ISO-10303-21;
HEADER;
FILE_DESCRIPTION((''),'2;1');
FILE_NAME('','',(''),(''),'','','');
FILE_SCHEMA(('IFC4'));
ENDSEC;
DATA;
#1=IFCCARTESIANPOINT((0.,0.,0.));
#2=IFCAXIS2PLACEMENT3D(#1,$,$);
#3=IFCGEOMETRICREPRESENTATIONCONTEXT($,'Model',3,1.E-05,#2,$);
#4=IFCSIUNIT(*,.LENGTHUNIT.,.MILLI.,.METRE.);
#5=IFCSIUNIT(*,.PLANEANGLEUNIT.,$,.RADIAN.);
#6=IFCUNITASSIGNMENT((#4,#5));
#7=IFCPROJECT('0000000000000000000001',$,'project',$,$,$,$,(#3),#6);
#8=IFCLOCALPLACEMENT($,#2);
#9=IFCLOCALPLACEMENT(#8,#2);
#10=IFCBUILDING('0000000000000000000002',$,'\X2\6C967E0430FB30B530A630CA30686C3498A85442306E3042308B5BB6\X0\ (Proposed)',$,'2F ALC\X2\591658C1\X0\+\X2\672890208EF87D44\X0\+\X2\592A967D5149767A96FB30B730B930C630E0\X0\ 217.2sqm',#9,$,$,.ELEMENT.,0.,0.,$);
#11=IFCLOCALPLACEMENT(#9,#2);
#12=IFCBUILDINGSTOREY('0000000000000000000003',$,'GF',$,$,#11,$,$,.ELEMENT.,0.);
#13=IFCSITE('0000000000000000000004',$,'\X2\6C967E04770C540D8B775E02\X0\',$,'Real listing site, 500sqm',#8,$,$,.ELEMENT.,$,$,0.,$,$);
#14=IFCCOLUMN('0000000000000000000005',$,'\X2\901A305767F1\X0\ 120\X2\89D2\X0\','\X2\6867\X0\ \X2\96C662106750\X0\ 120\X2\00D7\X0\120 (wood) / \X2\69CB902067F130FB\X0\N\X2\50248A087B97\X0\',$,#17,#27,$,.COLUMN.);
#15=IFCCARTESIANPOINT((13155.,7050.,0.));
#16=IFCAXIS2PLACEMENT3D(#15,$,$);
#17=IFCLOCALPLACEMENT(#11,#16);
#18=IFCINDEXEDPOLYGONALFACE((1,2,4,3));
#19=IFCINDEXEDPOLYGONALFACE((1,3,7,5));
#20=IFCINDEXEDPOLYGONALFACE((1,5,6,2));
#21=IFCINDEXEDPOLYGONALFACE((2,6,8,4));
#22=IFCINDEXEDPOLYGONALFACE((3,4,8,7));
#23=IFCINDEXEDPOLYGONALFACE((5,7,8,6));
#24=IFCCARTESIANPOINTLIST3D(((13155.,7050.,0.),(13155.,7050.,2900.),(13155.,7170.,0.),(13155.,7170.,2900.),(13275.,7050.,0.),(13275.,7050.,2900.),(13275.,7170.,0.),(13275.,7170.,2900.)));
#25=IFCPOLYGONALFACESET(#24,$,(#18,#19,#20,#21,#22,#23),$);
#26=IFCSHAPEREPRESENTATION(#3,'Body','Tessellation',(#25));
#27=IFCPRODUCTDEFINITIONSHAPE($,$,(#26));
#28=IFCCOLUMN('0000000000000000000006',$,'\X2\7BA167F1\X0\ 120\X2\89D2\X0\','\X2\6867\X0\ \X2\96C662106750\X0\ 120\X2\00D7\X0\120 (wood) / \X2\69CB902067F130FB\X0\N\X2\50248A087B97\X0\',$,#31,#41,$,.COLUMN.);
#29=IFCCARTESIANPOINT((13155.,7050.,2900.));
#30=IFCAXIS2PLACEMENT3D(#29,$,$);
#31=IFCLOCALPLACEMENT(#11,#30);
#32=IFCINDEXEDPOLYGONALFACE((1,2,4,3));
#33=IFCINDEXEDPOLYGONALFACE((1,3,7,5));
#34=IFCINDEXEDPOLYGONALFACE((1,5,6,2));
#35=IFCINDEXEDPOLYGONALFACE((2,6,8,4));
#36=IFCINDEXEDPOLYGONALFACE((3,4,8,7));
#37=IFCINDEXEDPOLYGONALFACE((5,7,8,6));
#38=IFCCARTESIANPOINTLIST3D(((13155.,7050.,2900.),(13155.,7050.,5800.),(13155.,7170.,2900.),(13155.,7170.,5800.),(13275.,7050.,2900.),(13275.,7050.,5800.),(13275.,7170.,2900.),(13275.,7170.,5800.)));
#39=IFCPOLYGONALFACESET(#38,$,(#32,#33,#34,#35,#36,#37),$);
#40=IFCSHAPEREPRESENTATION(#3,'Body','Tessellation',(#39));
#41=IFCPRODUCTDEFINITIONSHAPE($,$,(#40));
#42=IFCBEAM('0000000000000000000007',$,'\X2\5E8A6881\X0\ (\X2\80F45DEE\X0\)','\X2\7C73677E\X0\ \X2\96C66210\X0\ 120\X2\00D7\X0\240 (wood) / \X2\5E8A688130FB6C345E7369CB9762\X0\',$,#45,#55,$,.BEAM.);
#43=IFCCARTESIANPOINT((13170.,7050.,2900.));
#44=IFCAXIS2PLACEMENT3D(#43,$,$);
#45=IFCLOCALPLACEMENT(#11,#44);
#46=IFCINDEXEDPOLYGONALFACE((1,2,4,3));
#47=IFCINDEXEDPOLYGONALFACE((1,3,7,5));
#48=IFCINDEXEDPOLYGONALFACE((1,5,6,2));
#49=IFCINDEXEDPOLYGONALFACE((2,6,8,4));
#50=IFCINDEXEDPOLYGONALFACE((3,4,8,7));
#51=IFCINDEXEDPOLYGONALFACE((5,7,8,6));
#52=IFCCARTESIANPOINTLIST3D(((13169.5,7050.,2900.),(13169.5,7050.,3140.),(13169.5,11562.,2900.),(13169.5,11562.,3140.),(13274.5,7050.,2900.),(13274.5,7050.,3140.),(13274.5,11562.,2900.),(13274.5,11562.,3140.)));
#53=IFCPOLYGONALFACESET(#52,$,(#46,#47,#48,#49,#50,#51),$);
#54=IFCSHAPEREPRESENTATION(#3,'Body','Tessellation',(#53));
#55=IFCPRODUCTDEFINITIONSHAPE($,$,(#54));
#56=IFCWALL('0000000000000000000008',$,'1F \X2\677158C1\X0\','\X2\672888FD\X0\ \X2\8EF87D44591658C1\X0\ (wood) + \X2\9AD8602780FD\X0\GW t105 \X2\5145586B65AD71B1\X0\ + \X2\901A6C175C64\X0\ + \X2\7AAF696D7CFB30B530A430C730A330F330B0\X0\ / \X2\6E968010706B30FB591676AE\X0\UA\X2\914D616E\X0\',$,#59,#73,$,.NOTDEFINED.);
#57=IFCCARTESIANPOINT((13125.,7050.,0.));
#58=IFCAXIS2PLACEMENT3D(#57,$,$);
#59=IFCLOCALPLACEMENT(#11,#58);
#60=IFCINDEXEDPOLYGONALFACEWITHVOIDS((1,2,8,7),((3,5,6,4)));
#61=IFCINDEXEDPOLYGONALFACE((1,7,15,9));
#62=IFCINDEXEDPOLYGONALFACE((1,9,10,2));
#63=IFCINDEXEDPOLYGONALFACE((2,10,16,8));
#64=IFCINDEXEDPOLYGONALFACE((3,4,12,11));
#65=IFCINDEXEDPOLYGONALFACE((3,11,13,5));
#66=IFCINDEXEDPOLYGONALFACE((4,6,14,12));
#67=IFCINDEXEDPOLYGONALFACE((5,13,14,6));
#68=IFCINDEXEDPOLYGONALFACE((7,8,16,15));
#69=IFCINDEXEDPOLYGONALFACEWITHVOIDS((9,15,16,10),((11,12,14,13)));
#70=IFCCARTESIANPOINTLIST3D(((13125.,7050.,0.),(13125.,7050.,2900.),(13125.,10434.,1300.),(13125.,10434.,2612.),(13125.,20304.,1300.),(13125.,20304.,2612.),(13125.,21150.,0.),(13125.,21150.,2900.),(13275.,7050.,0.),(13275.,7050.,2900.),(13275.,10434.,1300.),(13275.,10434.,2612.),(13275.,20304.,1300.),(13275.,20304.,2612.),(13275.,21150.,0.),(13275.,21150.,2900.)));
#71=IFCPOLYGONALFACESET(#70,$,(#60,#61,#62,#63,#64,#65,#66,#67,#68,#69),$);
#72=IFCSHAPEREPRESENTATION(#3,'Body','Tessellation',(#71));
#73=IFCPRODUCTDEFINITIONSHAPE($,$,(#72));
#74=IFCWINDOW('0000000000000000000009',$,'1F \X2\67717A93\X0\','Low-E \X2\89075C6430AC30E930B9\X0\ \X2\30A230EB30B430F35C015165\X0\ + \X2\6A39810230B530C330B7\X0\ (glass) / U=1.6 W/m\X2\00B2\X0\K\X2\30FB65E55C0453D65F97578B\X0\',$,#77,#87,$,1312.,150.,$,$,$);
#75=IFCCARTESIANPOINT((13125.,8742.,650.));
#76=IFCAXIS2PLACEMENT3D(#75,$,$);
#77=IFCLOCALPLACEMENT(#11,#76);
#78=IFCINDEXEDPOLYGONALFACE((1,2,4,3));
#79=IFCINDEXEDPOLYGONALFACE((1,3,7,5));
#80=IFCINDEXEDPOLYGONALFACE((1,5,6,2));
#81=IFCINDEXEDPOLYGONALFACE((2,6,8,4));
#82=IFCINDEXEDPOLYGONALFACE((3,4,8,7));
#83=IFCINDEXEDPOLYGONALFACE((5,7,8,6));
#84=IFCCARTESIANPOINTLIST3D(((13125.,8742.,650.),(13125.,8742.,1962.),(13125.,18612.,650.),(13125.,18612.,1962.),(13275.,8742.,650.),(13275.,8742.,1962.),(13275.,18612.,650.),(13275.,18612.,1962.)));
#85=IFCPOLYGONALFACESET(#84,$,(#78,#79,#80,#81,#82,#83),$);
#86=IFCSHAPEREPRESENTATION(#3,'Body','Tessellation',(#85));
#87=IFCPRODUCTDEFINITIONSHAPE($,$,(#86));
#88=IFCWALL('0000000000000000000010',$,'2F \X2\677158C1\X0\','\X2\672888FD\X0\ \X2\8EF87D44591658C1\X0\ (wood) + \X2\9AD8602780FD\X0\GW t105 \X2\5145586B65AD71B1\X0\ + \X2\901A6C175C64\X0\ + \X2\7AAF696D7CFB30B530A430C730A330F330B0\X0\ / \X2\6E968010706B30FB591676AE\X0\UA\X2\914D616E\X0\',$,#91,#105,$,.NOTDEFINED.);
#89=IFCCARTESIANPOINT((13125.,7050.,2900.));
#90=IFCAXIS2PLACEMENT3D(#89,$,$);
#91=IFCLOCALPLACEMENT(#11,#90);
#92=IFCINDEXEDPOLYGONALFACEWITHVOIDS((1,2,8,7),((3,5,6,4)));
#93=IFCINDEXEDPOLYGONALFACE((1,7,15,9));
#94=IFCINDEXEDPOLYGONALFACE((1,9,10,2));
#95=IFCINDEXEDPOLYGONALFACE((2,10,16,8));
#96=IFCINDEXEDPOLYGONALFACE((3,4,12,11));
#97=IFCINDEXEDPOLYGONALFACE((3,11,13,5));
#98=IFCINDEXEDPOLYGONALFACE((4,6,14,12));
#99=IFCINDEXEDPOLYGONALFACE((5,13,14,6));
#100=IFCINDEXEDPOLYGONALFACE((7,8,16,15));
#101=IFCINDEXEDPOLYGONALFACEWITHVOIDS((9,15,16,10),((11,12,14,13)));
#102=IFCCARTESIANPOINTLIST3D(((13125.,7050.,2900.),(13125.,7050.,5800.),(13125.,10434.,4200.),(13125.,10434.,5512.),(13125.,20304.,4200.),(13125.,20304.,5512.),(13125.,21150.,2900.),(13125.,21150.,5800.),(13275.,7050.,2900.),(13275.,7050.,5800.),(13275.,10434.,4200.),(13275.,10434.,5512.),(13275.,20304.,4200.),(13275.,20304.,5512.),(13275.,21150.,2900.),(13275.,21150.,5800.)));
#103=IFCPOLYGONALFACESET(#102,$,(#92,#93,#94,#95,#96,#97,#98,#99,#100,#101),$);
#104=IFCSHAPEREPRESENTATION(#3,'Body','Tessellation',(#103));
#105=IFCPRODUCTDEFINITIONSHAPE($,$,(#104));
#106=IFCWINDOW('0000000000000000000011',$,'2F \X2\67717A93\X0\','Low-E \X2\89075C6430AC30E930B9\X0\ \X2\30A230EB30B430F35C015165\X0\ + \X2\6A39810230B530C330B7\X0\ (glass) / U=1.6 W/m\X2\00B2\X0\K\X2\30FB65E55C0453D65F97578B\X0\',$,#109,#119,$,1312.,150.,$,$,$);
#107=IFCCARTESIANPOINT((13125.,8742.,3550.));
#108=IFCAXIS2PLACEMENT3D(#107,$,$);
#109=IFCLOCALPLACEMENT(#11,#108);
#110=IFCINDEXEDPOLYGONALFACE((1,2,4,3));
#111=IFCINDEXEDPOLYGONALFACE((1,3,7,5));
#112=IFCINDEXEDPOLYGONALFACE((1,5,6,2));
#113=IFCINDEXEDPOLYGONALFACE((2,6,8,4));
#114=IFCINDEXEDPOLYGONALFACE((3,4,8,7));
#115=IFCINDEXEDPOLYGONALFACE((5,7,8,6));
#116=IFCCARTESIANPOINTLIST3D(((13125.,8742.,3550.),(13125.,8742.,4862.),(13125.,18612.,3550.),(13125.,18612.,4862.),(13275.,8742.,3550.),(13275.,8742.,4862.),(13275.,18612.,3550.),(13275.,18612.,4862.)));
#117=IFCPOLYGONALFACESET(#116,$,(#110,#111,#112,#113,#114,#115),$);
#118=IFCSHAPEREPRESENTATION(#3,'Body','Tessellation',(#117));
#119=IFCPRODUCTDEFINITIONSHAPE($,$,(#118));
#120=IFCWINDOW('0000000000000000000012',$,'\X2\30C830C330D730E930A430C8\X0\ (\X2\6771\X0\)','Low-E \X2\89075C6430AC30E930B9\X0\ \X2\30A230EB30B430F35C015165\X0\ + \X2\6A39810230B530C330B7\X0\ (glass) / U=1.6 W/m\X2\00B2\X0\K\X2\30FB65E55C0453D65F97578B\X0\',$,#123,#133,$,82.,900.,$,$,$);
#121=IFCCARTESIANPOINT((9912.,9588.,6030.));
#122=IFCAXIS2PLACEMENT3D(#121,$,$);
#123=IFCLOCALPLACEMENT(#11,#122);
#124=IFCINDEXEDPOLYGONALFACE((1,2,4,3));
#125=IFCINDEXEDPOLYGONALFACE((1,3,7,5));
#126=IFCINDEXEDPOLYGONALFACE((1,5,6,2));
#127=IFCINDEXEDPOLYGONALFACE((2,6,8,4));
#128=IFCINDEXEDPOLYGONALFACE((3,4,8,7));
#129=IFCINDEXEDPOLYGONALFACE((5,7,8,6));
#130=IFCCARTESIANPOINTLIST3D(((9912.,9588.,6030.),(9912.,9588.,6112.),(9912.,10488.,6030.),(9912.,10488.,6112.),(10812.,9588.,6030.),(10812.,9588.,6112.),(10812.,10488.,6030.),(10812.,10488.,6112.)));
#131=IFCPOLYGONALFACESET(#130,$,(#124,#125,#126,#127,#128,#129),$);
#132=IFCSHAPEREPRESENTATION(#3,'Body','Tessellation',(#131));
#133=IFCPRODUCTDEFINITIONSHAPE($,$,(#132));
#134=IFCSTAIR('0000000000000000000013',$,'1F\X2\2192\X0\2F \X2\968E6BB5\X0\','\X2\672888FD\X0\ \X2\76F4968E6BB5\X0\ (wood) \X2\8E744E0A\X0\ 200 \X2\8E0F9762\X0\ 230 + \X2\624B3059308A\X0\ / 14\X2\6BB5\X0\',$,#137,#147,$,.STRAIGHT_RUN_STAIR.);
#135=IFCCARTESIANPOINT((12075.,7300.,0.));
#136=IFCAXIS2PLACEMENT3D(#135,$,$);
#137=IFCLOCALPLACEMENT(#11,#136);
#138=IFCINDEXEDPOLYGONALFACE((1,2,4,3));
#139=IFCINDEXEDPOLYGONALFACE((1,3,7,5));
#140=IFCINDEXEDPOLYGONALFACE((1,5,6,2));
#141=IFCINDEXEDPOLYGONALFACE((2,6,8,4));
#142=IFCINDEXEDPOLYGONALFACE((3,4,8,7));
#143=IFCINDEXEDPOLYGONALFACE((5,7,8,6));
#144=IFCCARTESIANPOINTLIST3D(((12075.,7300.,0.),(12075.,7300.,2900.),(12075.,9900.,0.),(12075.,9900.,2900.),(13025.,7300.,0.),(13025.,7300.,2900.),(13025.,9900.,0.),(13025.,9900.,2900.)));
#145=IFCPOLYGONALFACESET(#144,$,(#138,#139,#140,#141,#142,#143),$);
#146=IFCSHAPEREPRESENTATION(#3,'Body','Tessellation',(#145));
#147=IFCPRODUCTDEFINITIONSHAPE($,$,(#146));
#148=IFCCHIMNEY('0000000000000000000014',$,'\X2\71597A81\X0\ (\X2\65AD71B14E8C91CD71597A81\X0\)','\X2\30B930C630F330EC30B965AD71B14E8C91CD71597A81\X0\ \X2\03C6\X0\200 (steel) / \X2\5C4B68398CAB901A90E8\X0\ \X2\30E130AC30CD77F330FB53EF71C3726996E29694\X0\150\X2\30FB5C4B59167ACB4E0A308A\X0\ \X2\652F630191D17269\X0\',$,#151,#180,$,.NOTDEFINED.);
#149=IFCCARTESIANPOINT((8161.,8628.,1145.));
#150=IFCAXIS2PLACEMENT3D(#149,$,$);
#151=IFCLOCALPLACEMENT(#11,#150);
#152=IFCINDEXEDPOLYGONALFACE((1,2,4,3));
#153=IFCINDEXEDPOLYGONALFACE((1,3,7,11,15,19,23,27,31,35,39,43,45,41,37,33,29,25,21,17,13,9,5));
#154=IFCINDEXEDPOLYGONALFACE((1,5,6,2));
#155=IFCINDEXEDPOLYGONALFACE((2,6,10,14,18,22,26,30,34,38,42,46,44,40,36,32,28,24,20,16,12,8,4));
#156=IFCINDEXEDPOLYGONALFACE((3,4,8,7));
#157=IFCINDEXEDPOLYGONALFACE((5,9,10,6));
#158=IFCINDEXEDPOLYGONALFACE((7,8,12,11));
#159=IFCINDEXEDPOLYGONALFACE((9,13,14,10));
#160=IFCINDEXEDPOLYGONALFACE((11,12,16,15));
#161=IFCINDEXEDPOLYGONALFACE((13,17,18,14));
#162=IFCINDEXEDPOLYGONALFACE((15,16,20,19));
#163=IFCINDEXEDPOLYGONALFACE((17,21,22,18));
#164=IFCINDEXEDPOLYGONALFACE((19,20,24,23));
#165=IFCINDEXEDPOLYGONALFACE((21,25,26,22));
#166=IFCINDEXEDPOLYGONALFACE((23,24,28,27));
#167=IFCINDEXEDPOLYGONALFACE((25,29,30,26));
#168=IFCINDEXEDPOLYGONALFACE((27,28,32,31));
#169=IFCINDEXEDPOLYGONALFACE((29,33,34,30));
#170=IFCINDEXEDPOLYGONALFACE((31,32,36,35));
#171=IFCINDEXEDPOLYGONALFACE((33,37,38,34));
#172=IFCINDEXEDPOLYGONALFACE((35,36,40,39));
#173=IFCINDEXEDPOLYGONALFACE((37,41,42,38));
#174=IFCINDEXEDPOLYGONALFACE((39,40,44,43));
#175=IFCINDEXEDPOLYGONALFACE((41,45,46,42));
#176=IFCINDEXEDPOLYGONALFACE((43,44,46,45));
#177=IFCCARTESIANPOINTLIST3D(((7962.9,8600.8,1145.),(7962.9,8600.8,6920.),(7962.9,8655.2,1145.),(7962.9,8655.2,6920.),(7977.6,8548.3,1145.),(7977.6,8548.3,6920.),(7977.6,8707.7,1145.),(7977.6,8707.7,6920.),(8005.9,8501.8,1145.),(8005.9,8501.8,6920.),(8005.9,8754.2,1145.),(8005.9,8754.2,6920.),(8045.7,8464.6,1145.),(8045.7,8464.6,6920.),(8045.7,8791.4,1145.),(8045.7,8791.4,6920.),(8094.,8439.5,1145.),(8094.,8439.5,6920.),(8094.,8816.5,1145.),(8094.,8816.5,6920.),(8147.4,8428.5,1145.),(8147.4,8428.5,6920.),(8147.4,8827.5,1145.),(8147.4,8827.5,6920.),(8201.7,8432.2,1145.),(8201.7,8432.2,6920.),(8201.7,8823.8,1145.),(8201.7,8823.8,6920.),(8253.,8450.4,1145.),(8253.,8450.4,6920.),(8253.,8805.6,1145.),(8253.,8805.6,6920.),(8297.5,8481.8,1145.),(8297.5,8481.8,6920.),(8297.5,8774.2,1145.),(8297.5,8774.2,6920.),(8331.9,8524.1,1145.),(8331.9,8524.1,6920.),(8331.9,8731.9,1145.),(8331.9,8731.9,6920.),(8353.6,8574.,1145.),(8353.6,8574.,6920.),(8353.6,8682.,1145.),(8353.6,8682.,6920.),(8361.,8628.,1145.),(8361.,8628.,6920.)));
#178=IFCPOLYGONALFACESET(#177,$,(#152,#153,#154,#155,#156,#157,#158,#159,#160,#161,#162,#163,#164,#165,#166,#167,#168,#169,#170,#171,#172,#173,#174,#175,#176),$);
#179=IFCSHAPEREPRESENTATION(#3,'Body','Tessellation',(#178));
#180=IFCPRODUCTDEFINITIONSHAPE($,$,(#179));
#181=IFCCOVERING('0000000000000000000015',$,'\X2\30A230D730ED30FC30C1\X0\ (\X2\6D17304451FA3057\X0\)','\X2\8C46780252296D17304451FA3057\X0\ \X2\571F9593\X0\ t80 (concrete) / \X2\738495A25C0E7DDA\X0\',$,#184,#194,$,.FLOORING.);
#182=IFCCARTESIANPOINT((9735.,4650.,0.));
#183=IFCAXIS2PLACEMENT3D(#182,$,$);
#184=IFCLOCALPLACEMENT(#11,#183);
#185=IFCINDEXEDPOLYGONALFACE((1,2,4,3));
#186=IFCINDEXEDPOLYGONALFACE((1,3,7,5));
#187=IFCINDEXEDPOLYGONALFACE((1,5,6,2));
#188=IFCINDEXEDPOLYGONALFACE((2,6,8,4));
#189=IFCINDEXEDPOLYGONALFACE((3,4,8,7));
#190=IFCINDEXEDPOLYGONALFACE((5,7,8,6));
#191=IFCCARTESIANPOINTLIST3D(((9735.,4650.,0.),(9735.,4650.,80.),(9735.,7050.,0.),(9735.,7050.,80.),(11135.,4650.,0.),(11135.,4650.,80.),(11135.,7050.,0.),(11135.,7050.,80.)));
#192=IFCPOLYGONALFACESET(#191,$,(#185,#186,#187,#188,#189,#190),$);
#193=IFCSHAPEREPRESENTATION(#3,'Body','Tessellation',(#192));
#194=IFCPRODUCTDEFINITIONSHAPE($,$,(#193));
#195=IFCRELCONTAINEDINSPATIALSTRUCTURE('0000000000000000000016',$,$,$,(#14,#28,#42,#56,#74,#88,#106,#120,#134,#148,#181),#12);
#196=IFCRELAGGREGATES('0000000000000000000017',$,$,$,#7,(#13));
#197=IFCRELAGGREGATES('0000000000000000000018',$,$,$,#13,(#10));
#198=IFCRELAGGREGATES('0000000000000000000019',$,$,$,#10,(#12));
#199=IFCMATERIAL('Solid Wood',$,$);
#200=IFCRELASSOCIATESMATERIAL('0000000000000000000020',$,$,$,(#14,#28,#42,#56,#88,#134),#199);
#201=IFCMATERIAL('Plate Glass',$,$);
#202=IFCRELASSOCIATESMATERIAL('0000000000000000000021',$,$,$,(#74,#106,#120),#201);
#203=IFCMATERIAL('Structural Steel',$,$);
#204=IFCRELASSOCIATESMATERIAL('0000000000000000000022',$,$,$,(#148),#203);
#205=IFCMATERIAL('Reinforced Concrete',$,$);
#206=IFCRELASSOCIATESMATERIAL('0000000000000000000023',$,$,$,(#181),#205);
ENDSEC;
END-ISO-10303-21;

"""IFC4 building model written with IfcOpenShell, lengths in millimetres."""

from ifc_helpers import new_model, si_unit, frame, frame_2d, origin, origin_2d, place, context, project, spatial, rectangle, circle, extrude, material, element, fill, save


model = new_model("IFC4")

# Units and contexts
model_context = context("Model", 3, precision=1e-05, world=origin())
ifc_project = project(units=[si_unit("LENGTHUNIT", "METRE", prefix="MILLI"), si_unit("PLANEANGLEUNIT", "RADIAN")], contexts=[model_context])

# Site, building, storey
site_placement = place(None, origin())
site = spatial("IfcSite", under=ifc_project, at=site_placement, Name="沖縄県名護市", ObjectType="Real listing site, 500sqm", CompositionType="ELEMENT", RefElevation=0.0)
building_placement = place(site_placement, origin())
building = spatial("IfcBuilding", under=site, at=building_placement, Name="沖縄・サウナと水風呂のある家 (Proposed)", ObjectType="2F ALC外壁+木造軸組+太陽光発電システム 217.2sqm", CompositionType="ELEMENT", ElevationOfRefHeight=0.0, ElevationOfTerrain=0.0)
storey_placement = place(building_placement, origin())
storey = spatial("IfcBuildingStorey", under=building, at=storey_placement, Name="GF", CompositionType="ELEMENT", Elevation=0.0)

# Columns
ifc_material_1 = material(Name="Solid Wood")
column_1_placement = place(storey_placement, frame((13155.0, 7050.0, 0.0)))
element("IfcColumn", 1, at=column_1_placement, inside=storey, material=ifc_material_1, Name="通し柱 120角", Description="桧 集成材 120×120 (wood) / 構造柱・N値計算", PredefinedType="COLUMN", context=model_context, shape_type="SweptSolid", body=[
    extrude(rectangle(XDim=120.0, YDim=120.0, at=frame_2d((60.0, 60.0))), frame((13155.0, 7050.0, 0.0)), (0.0, 0.0, 1.0), 2900.0),
])
column_2_placement = place(storey_placement, frame((13155.0, 7050.0, 2900.0)))
element("IfcColumn", 2, at=column_2_placement, inside=storey, material=ifc_material_1, Name="管柱 120角", Description="桧 集成材 120×120 (wood) / 構造柱・N値計算", PredefinedType="COLUMN", context=model_context, shape_type="SweptSolid", body=[
    extrude(rectangle(XDim=120.0, YDim=120.0, at=frame_2d((60.0, 60.0))), frame((13155.0, 7050.0, 2900.0)), (0.0, 0.0, 1.0), 2900.0),
])

# Beam
beam_1_placement = place(storey_placement, frame((13170.0, 7050.0, 2900.0)))
element("IfcBeam", 3, at=beam_1_placement, inside=storey, material=ifc_material_1, Name="床梁 (胴差)", Description="米松 集成 120×240 (wood) / 床梁・水平構面", PredefinedType="BEAM", context=model_context, shape_type="SweptSolid", body=[
    extrude(rectangle(XDim=105.0, YDim=4512.0, at=frame_2d((52.0, 2256.0))), frame((13170.0, 7050.0, 2900.0)), (0.0, 0.0, 1.0), 240.0),
])

# Wall, opening, window
wall_1_placement = place(storey_placement, frame((13125.0, 7050.0, 0.0)))
wall_1 = element("IfcWall", 4, at=wall_1_placement, inside=storey, material=ifc_material_1, Name="1F 東壁", Description="木製 軸組外壁 (wood) + 高性能GW t105 充填断熱 + 通気層 + 窯業系サイディング / 準耐火・外皮UA配慮", PredefinedType="NOTDEFINED", context=model_context, shape_type="SweptSolid", body=[
    extrude(rectangle(XDim=150.0, YDim=14100.0, at=frame_2d((75.0, 7050.0))), frame((13125.0, 7050.0, 0.0)), (0.0, 0.0, 1.0), 2900.0),
])
opening_1_placement = place(storey_placement, frame((13125.0, 8742.0, 650.0)))
opening_1 = element("IfcOpeningElement", 5, at=opening_1_placement, cuts=wall_1, PredefinedType="NOTDEFINED", context=model_context, shape_type="SweptSolid", body=[
    extrude(rectangle(XDim=150.0, YDim=9870.0, at=frame_2d((75.0, 4935.0))), frame((13125.0, 8742.0, 650.0)), (0.0, 0.0, 1.0), 1312.0),
])
ifc_material_2 = material(Name="Plate Glass")
window_1_placement = place(storey_placement, frame((13125.0, 8742.0, 650.0)))
window_1 = element("IfcWindow", 6, at=window_1_placement, inside=storey, material=ifc_material_2, Name="1F 東窓", Description="Low-E 複層ガラス アルゴン封入 + 樹脂サッシ (glass) / U=1.6 W/m²K・日射取得型", OverallHeight=1312.0, OverallWidth=150.0, context=model_context, shape_type="SweptSolid", body=[
    extrude(rectangle(XDim=150.0, YDim=9870.0, at=frame_2d((75.0, 4935.0))), frame((13125.0, 8742.0, 650.0)), (0.0, 0.0, 1.0), 1312.0),
])
fill(opening_1, window_1)

# Wall, opening, window
wall_2_placement = place(storey_placement, frame((13125.0, 7050.0, 2900.0)))
wall_2 = element("IfcWall", 7, at=wall_2_placement, inside=storey, material=ifc_material_1, Name="2F 東壁", Description="木製 軸組外壁 (wood) + 高性能GW t105 充填断熱 + 通気層 + 窯業系サイディング / 準耐火・外皮UA配慮", PredefinedType="NOTDEFINED", context=model_context, shape_type="SweptSolid", body=[
    extrude(rectangle(XDim=150.0, YDim=14100.0, at=frame_2d((75.0, 7050.0))), frame((13125.0, 7050.0, 2900.0)), (0.0, 0.0, 1.0), 2900.0),
])
opening_2_placement = place(storey_placement, frame((13125.0, 8742.0, 3550.0)))
opening_2 = element("IfcOpeningElement", 8, at=opening_2_placement, cuts=wall_2, PredefinedType="NOTDEFINED", context=model_context, shape_type="SweptSolid", body=[
    extrude(rectangle(XDim=150.0, YDim=9870.0, at=frame_2d((75.0, 4935.0))), frame((13125.0, 8742.0, 3550.0)), (0.0, 0.0, 1.0), 1312.0),
])
window_2_placement = place(storey_placement, frame((13125.0, 8742.0, 3550.0)))
window_2 = element("IfcWindow", 9, at=window_2_placement, inside=storey, material=ifc_material_2, Name="2F 東窓", Description="Low-E 複層ガラス アルゴン封入 + 樹脂サッシ (glass) / U=1.6 W/m²K・日射取得型", OverallHeight=1312.0, OverallWidth=150.0, context=model_context, shape_type="SweptSolid", body=[
    extrude(rectangle(XDim=150.0, YDim=9870.0, at=frame_2d((75.0, 4935.0))), frame((13125.0, 8742.0, 3550.0)), (0.0, 0.0, 1.0), 1312.0),
])
fill(opening_2, window_2)

# Window
window_3_placement = place(storey_placement, frame((9912.0, 9588.0, 6030.0)))
element("IfcWindow", 10, at=window_3_placement, inside=storey, material=ifc_material_2, Name="トップライト (東)", Description="Low-E 複層ガラス アルゴン封入 + 樹脂サッシ (glass) / U=1.6 W/m²K・日射取得型", OverallHeight=82.0, OverallWidth=900.0, context=model_context, shape_type="SweptSolid", body=[
    extrude(rectangle(XDim=900.0, YDim=900.0, at=frame_2d((450.0, 450.0))), frame((9912.0, 9588.0, 6030.0)), (0.0, 0.0, 1.0), 82.0),
])

# Stair
stair_placement = place(storey_placement, frame((12075.0, 7300.0, 0.0)))
element("IfcStair", 11, at=stair_placement, inside=storey, material=ifc_material_1, Name="1F→2F 階段", Description="木製 直階段 (wood) 蹴上 200 踏面 230 + 手すり / 14段", PredefinedType="STRAIGHT_RUN_STAIR", context=model_context, shape_type="SweptSolid", body=[
    extrude(rectangle(XDim=950.0, YDim=2600.0, at=frame_2d((475.0, 1300.0))), frame((12075.0, 7300.0, 0.0)), (0.0, 0.0, 1.0), 2900.0),
])

# Chimney
ifc_material_3 = material(Name="Structural Steel")
chimney_placement = place(storey_placement, frame((8161.0, 8628.0, 1145.0)))
element("IfcChimney", 12, at=chimney_placement, inside=storey, material=ifc_material_3, Name="煙突 (断熱二重煙突)", Description="ステンレス断熱二重煙突 φ200 (steel) / 屋根貫通部 メガネ石・可燃物離隔150・屋外立上り 支持金物", PredefinedType="NOTDEFINED", context=model_context, shape_type="SweptSolid", body=[
    extrude(circle(Radius=200.0, at=origin_2d()), frame((8161.0, 8628.0, 1145.0)), (0.0, 0.0, 1.0), 5775.0),
])

# Covering
ifc_material_4 = material(Name="Reinforced Concrete")
covering_1_placement = place(storey_placement, frame((9735.0, 4650.0, 0.0)))
element("IfcCovering", 13, at=covering_1_placement, inside=storey, material=ifc_material_4, Name="アプローチ (洗い出し)", Description="豆砂利洗い出し 土間 t80 (concrete) / 玄関導線", PredefinedType="FLOORING", context=model_context, shape_type="SweptSolid", body=[
    extrude(rectangle(XDim=1400.0, YDim=2400.0, at=frame_2d((700.0, 1200.0))), frame((9735.0, 4650.0, 0.0)), (0.0, 0.0, 1.0), 80.0),
])

save(model, "model.ifc")
